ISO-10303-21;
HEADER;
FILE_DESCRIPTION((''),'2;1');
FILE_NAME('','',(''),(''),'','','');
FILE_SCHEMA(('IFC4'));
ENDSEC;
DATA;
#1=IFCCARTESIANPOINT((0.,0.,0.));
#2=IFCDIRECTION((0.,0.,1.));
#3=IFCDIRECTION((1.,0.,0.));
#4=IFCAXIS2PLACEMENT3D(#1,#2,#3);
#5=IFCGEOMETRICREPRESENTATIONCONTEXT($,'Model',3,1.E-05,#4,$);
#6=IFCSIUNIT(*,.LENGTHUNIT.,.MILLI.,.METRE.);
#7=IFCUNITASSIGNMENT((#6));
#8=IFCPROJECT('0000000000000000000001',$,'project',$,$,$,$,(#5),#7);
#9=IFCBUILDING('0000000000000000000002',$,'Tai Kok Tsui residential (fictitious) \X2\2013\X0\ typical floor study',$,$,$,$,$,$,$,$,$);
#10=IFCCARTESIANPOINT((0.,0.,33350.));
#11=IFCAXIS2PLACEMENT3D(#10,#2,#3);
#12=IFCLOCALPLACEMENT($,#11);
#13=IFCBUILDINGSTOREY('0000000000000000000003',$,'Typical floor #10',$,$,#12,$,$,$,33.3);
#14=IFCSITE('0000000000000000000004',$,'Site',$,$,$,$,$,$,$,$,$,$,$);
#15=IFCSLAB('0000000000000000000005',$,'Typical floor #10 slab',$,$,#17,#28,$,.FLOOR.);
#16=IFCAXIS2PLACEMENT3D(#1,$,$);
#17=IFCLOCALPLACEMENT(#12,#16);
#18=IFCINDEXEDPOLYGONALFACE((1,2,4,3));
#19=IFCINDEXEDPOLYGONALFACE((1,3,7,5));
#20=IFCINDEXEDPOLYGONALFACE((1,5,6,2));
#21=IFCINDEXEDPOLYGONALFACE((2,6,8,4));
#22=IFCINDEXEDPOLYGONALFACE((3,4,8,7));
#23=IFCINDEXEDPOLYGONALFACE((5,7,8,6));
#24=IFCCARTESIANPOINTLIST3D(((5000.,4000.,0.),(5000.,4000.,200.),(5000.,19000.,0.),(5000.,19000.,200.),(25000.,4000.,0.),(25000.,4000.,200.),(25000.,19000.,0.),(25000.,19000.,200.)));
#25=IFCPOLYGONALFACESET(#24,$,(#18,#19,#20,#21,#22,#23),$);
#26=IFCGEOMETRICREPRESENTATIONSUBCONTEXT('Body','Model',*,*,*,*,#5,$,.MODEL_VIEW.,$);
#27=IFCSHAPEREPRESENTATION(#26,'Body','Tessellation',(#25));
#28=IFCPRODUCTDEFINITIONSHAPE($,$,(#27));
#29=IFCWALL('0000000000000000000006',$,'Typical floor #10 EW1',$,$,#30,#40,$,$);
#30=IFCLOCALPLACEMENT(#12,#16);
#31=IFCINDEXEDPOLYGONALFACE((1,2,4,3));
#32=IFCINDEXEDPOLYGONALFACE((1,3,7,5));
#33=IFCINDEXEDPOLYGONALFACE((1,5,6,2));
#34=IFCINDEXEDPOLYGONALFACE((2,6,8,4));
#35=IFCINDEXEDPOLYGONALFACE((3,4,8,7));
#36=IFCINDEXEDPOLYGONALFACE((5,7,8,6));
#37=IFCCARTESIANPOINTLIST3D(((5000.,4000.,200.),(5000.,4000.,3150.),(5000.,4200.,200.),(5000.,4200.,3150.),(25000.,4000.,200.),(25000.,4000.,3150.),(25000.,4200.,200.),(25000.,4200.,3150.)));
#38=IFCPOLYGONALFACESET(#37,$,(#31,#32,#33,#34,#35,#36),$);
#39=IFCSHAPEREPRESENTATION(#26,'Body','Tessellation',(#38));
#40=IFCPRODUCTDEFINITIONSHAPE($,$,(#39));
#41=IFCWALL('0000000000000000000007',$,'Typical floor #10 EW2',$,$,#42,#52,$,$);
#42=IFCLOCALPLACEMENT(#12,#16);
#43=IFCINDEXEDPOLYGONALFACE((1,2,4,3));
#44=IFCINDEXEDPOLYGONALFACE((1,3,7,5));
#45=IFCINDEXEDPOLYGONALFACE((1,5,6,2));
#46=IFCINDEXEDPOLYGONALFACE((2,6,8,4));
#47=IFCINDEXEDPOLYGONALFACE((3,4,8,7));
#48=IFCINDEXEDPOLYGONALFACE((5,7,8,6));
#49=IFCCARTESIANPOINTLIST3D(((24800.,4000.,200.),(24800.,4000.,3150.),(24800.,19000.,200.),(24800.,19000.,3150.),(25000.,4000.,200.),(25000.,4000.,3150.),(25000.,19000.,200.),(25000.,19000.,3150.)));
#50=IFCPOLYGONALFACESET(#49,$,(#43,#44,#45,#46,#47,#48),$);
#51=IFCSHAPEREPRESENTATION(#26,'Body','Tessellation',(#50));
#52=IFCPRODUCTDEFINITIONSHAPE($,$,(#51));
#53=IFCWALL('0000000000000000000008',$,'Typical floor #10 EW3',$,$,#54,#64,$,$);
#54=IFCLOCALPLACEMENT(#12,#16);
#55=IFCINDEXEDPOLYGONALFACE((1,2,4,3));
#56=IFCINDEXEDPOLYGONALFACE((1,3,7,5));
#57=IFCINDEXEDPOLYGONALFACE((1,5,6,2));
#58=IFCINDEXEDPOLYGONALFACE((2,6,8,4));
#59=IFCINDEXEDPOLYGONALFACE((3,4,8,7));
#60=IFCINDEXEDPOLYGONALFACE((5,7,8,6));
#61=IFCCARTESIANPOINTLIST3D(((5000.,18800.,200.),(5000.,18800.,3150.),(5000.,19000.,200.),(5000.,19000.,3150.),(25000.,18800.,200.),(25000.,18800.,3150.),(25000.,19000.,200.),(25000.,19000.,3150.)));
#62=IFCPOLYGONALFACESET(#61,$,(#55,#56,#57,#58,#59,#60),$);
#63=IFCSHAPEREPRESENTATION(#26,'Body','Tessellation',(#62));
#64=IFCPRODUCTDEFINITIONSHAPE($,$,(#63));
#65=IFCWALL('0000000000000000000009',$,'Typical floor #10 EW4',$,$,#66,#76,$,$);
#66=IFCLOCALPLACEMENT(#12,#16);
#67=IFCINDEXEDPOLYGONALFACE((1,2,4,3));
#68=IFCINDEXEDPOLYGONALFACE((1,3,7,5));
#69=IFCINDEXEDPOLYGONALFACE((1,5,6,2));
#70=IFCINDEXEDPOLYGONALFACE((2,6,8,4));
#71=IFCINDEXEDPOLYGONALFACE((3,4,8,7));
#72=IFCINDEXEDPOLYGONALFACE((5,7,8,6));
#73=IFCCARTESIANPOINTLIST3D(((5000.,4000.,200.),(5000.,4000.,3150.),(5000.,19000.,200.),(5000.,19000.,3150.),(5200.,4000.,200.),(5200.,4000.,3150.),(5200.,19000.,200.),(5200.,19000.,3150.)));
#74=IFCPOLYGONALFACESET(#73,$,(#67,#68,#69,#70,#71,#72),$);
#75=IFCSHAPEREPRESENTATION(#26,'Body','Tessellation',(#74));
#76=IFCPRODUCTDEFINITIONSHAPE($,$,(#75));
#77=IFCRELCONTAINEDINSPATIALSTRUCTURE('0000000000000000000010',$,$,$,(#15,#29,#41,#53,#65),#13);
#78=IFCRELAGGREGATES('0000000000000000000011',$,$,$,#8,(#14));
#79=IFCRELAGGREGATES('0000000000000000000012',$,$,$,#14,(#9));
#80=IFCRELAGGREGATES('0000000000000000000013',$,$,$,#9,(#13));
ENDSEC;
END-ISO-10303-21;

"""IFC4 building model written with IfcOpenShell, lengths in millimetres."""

from ifc_helpers import new_model, si_unit, frame, origin_with_axes, place, context, subcontext, project, spatial, indexed_curve, outline, extrude, element, save


model = new_model("IFC4")

# Units and contexts
model_context = context("Model", 3, precision=1e-05, world=origin_with_axes())
body_context = subcontext(model_context, "Body", "Model", "MODEL_VIEW")
ifc_project = project(units=[si_unit("LENGTHUNIT", "METRE", prefix="MILLI")], contexts=[model_context])

# Site, building, storey
site = spatial("IfcSite", under=ifc_project, Name="Site")
building = spatial("IfcBuilding", under=site, Name="Tai Kok Tsui residential (fictitious) – typical floor study")
storey_placement = place(None, frame((0.0, 0.0, 33350.0), z_axis=(0.0, 0.0, 1.0), x_axis=(1.0, 0.0, 0.0)))
storey = spatial("IfcBuildingStorey", under=building, at=storey_placement, Name="Typical floor #10", Elevation=33.3)

# Slab
slab_placement = place(storey_placement, origin_with_axes())
element("IfcSlab", 1, at=slab_placement, inside=storey, Name="Typical floor #10 slab", PredefinedType="FLOOR", context=body_context, shape_type="SweptSolid", body=[
    extrude(outline(indexed_curve([(5000.0, 4000.0), (25000.0, 4000.0), (25000.0, 19000.0), (5000.0, 19000.0)])), None, (0.0, 0.0, 1.0), 200.0),
])

# Walls
wall_1_placement = place(storey_placement, frame((5000.0, 4000.0, 200.0), z_axis=(0.0, 0.0, 1.0), x_axis=(1.0, 0.0, 0.0)))
element("IfcWall", 2, at=wall_1_placement, inside=storey, Name="Typical floor #10 EW1", context=body_context, shape_type="SweptSolid", body=[
    extrude(outline(indexed_curve([(0.0, 0.0), (0.0, 200.0), (20000.0, 200.0), (20000.0, 0.0), (0.0, 0.0)], self_intersect=False)), origin_with_axes(), (0.0, 0.0, 1.0), 2950.0),
])
wall_2_placement = place(storey_placement, frame((25000.0, 4000.0, 200.0), z_axis=(0.0, 0.0, 1.0), x_axis=(0.0, 1.0, 0.0)))
element("IfcWall", 3, at=wall_2_placement, inside=storey, Name="Typical floor #10 EW2", context=body_context, shape_type="SweptSolid", body=[
    extrude(outline(indexed_curve([(0.0, 0.0), (0.0, 200.0), (15000.0, 200.0), (15000.0, 0.0), (0.0, 0.0)], self_intersect=False)), origin_with_axes(), (0.0, 0.0, 1.0), 2950.0),
])
wall_3_placement = place(storey_placement, frame((25000.0, 19000.0, 200.0), z_axis=(0.0, 0.0, 1.0), x_axis=(-1.0, 0.0, 0.0)))
element("IfcWall", 4, at=wall_3_placement, inside=storey, Name="Typical floor #10 EW3", context=body_context, shape_type="SweptSolid", body=[
    extrude(outline(indexed_curve([(0.0, 0.0), (0.0, 200.0), (20000.0, 200.0), (20000.0, 0.0), (0.0, 0.0)], self_intersect=False)), origin_with_axes(), (0.0, 0.0, 1.0), 2950.0),
])
wall_4_placement = place(storey_placement, frame((5000.0, 19000.0, 200.0), z_axis=(0.0, 0.0, 1.0), x_axis=(0.0, -1.0, 0.0)))
element("IfcWall", 5, at=wall_4_placement, inside=storey, Name="Typical floor #10 EW4", context=body_context, shape_type="SweptSolid", body=[
    extrude(outline(indexed_curve([(0.0, 0.0), (0.0, 200.0), (15000.0, 200.0), (15000.0, 0.0), (0.0, 0.0)], self_intersect=False)), origin_with_axes(), (0.0, 0.0, 1.0), 2950.0),
])

save(model, "model.ifc")
